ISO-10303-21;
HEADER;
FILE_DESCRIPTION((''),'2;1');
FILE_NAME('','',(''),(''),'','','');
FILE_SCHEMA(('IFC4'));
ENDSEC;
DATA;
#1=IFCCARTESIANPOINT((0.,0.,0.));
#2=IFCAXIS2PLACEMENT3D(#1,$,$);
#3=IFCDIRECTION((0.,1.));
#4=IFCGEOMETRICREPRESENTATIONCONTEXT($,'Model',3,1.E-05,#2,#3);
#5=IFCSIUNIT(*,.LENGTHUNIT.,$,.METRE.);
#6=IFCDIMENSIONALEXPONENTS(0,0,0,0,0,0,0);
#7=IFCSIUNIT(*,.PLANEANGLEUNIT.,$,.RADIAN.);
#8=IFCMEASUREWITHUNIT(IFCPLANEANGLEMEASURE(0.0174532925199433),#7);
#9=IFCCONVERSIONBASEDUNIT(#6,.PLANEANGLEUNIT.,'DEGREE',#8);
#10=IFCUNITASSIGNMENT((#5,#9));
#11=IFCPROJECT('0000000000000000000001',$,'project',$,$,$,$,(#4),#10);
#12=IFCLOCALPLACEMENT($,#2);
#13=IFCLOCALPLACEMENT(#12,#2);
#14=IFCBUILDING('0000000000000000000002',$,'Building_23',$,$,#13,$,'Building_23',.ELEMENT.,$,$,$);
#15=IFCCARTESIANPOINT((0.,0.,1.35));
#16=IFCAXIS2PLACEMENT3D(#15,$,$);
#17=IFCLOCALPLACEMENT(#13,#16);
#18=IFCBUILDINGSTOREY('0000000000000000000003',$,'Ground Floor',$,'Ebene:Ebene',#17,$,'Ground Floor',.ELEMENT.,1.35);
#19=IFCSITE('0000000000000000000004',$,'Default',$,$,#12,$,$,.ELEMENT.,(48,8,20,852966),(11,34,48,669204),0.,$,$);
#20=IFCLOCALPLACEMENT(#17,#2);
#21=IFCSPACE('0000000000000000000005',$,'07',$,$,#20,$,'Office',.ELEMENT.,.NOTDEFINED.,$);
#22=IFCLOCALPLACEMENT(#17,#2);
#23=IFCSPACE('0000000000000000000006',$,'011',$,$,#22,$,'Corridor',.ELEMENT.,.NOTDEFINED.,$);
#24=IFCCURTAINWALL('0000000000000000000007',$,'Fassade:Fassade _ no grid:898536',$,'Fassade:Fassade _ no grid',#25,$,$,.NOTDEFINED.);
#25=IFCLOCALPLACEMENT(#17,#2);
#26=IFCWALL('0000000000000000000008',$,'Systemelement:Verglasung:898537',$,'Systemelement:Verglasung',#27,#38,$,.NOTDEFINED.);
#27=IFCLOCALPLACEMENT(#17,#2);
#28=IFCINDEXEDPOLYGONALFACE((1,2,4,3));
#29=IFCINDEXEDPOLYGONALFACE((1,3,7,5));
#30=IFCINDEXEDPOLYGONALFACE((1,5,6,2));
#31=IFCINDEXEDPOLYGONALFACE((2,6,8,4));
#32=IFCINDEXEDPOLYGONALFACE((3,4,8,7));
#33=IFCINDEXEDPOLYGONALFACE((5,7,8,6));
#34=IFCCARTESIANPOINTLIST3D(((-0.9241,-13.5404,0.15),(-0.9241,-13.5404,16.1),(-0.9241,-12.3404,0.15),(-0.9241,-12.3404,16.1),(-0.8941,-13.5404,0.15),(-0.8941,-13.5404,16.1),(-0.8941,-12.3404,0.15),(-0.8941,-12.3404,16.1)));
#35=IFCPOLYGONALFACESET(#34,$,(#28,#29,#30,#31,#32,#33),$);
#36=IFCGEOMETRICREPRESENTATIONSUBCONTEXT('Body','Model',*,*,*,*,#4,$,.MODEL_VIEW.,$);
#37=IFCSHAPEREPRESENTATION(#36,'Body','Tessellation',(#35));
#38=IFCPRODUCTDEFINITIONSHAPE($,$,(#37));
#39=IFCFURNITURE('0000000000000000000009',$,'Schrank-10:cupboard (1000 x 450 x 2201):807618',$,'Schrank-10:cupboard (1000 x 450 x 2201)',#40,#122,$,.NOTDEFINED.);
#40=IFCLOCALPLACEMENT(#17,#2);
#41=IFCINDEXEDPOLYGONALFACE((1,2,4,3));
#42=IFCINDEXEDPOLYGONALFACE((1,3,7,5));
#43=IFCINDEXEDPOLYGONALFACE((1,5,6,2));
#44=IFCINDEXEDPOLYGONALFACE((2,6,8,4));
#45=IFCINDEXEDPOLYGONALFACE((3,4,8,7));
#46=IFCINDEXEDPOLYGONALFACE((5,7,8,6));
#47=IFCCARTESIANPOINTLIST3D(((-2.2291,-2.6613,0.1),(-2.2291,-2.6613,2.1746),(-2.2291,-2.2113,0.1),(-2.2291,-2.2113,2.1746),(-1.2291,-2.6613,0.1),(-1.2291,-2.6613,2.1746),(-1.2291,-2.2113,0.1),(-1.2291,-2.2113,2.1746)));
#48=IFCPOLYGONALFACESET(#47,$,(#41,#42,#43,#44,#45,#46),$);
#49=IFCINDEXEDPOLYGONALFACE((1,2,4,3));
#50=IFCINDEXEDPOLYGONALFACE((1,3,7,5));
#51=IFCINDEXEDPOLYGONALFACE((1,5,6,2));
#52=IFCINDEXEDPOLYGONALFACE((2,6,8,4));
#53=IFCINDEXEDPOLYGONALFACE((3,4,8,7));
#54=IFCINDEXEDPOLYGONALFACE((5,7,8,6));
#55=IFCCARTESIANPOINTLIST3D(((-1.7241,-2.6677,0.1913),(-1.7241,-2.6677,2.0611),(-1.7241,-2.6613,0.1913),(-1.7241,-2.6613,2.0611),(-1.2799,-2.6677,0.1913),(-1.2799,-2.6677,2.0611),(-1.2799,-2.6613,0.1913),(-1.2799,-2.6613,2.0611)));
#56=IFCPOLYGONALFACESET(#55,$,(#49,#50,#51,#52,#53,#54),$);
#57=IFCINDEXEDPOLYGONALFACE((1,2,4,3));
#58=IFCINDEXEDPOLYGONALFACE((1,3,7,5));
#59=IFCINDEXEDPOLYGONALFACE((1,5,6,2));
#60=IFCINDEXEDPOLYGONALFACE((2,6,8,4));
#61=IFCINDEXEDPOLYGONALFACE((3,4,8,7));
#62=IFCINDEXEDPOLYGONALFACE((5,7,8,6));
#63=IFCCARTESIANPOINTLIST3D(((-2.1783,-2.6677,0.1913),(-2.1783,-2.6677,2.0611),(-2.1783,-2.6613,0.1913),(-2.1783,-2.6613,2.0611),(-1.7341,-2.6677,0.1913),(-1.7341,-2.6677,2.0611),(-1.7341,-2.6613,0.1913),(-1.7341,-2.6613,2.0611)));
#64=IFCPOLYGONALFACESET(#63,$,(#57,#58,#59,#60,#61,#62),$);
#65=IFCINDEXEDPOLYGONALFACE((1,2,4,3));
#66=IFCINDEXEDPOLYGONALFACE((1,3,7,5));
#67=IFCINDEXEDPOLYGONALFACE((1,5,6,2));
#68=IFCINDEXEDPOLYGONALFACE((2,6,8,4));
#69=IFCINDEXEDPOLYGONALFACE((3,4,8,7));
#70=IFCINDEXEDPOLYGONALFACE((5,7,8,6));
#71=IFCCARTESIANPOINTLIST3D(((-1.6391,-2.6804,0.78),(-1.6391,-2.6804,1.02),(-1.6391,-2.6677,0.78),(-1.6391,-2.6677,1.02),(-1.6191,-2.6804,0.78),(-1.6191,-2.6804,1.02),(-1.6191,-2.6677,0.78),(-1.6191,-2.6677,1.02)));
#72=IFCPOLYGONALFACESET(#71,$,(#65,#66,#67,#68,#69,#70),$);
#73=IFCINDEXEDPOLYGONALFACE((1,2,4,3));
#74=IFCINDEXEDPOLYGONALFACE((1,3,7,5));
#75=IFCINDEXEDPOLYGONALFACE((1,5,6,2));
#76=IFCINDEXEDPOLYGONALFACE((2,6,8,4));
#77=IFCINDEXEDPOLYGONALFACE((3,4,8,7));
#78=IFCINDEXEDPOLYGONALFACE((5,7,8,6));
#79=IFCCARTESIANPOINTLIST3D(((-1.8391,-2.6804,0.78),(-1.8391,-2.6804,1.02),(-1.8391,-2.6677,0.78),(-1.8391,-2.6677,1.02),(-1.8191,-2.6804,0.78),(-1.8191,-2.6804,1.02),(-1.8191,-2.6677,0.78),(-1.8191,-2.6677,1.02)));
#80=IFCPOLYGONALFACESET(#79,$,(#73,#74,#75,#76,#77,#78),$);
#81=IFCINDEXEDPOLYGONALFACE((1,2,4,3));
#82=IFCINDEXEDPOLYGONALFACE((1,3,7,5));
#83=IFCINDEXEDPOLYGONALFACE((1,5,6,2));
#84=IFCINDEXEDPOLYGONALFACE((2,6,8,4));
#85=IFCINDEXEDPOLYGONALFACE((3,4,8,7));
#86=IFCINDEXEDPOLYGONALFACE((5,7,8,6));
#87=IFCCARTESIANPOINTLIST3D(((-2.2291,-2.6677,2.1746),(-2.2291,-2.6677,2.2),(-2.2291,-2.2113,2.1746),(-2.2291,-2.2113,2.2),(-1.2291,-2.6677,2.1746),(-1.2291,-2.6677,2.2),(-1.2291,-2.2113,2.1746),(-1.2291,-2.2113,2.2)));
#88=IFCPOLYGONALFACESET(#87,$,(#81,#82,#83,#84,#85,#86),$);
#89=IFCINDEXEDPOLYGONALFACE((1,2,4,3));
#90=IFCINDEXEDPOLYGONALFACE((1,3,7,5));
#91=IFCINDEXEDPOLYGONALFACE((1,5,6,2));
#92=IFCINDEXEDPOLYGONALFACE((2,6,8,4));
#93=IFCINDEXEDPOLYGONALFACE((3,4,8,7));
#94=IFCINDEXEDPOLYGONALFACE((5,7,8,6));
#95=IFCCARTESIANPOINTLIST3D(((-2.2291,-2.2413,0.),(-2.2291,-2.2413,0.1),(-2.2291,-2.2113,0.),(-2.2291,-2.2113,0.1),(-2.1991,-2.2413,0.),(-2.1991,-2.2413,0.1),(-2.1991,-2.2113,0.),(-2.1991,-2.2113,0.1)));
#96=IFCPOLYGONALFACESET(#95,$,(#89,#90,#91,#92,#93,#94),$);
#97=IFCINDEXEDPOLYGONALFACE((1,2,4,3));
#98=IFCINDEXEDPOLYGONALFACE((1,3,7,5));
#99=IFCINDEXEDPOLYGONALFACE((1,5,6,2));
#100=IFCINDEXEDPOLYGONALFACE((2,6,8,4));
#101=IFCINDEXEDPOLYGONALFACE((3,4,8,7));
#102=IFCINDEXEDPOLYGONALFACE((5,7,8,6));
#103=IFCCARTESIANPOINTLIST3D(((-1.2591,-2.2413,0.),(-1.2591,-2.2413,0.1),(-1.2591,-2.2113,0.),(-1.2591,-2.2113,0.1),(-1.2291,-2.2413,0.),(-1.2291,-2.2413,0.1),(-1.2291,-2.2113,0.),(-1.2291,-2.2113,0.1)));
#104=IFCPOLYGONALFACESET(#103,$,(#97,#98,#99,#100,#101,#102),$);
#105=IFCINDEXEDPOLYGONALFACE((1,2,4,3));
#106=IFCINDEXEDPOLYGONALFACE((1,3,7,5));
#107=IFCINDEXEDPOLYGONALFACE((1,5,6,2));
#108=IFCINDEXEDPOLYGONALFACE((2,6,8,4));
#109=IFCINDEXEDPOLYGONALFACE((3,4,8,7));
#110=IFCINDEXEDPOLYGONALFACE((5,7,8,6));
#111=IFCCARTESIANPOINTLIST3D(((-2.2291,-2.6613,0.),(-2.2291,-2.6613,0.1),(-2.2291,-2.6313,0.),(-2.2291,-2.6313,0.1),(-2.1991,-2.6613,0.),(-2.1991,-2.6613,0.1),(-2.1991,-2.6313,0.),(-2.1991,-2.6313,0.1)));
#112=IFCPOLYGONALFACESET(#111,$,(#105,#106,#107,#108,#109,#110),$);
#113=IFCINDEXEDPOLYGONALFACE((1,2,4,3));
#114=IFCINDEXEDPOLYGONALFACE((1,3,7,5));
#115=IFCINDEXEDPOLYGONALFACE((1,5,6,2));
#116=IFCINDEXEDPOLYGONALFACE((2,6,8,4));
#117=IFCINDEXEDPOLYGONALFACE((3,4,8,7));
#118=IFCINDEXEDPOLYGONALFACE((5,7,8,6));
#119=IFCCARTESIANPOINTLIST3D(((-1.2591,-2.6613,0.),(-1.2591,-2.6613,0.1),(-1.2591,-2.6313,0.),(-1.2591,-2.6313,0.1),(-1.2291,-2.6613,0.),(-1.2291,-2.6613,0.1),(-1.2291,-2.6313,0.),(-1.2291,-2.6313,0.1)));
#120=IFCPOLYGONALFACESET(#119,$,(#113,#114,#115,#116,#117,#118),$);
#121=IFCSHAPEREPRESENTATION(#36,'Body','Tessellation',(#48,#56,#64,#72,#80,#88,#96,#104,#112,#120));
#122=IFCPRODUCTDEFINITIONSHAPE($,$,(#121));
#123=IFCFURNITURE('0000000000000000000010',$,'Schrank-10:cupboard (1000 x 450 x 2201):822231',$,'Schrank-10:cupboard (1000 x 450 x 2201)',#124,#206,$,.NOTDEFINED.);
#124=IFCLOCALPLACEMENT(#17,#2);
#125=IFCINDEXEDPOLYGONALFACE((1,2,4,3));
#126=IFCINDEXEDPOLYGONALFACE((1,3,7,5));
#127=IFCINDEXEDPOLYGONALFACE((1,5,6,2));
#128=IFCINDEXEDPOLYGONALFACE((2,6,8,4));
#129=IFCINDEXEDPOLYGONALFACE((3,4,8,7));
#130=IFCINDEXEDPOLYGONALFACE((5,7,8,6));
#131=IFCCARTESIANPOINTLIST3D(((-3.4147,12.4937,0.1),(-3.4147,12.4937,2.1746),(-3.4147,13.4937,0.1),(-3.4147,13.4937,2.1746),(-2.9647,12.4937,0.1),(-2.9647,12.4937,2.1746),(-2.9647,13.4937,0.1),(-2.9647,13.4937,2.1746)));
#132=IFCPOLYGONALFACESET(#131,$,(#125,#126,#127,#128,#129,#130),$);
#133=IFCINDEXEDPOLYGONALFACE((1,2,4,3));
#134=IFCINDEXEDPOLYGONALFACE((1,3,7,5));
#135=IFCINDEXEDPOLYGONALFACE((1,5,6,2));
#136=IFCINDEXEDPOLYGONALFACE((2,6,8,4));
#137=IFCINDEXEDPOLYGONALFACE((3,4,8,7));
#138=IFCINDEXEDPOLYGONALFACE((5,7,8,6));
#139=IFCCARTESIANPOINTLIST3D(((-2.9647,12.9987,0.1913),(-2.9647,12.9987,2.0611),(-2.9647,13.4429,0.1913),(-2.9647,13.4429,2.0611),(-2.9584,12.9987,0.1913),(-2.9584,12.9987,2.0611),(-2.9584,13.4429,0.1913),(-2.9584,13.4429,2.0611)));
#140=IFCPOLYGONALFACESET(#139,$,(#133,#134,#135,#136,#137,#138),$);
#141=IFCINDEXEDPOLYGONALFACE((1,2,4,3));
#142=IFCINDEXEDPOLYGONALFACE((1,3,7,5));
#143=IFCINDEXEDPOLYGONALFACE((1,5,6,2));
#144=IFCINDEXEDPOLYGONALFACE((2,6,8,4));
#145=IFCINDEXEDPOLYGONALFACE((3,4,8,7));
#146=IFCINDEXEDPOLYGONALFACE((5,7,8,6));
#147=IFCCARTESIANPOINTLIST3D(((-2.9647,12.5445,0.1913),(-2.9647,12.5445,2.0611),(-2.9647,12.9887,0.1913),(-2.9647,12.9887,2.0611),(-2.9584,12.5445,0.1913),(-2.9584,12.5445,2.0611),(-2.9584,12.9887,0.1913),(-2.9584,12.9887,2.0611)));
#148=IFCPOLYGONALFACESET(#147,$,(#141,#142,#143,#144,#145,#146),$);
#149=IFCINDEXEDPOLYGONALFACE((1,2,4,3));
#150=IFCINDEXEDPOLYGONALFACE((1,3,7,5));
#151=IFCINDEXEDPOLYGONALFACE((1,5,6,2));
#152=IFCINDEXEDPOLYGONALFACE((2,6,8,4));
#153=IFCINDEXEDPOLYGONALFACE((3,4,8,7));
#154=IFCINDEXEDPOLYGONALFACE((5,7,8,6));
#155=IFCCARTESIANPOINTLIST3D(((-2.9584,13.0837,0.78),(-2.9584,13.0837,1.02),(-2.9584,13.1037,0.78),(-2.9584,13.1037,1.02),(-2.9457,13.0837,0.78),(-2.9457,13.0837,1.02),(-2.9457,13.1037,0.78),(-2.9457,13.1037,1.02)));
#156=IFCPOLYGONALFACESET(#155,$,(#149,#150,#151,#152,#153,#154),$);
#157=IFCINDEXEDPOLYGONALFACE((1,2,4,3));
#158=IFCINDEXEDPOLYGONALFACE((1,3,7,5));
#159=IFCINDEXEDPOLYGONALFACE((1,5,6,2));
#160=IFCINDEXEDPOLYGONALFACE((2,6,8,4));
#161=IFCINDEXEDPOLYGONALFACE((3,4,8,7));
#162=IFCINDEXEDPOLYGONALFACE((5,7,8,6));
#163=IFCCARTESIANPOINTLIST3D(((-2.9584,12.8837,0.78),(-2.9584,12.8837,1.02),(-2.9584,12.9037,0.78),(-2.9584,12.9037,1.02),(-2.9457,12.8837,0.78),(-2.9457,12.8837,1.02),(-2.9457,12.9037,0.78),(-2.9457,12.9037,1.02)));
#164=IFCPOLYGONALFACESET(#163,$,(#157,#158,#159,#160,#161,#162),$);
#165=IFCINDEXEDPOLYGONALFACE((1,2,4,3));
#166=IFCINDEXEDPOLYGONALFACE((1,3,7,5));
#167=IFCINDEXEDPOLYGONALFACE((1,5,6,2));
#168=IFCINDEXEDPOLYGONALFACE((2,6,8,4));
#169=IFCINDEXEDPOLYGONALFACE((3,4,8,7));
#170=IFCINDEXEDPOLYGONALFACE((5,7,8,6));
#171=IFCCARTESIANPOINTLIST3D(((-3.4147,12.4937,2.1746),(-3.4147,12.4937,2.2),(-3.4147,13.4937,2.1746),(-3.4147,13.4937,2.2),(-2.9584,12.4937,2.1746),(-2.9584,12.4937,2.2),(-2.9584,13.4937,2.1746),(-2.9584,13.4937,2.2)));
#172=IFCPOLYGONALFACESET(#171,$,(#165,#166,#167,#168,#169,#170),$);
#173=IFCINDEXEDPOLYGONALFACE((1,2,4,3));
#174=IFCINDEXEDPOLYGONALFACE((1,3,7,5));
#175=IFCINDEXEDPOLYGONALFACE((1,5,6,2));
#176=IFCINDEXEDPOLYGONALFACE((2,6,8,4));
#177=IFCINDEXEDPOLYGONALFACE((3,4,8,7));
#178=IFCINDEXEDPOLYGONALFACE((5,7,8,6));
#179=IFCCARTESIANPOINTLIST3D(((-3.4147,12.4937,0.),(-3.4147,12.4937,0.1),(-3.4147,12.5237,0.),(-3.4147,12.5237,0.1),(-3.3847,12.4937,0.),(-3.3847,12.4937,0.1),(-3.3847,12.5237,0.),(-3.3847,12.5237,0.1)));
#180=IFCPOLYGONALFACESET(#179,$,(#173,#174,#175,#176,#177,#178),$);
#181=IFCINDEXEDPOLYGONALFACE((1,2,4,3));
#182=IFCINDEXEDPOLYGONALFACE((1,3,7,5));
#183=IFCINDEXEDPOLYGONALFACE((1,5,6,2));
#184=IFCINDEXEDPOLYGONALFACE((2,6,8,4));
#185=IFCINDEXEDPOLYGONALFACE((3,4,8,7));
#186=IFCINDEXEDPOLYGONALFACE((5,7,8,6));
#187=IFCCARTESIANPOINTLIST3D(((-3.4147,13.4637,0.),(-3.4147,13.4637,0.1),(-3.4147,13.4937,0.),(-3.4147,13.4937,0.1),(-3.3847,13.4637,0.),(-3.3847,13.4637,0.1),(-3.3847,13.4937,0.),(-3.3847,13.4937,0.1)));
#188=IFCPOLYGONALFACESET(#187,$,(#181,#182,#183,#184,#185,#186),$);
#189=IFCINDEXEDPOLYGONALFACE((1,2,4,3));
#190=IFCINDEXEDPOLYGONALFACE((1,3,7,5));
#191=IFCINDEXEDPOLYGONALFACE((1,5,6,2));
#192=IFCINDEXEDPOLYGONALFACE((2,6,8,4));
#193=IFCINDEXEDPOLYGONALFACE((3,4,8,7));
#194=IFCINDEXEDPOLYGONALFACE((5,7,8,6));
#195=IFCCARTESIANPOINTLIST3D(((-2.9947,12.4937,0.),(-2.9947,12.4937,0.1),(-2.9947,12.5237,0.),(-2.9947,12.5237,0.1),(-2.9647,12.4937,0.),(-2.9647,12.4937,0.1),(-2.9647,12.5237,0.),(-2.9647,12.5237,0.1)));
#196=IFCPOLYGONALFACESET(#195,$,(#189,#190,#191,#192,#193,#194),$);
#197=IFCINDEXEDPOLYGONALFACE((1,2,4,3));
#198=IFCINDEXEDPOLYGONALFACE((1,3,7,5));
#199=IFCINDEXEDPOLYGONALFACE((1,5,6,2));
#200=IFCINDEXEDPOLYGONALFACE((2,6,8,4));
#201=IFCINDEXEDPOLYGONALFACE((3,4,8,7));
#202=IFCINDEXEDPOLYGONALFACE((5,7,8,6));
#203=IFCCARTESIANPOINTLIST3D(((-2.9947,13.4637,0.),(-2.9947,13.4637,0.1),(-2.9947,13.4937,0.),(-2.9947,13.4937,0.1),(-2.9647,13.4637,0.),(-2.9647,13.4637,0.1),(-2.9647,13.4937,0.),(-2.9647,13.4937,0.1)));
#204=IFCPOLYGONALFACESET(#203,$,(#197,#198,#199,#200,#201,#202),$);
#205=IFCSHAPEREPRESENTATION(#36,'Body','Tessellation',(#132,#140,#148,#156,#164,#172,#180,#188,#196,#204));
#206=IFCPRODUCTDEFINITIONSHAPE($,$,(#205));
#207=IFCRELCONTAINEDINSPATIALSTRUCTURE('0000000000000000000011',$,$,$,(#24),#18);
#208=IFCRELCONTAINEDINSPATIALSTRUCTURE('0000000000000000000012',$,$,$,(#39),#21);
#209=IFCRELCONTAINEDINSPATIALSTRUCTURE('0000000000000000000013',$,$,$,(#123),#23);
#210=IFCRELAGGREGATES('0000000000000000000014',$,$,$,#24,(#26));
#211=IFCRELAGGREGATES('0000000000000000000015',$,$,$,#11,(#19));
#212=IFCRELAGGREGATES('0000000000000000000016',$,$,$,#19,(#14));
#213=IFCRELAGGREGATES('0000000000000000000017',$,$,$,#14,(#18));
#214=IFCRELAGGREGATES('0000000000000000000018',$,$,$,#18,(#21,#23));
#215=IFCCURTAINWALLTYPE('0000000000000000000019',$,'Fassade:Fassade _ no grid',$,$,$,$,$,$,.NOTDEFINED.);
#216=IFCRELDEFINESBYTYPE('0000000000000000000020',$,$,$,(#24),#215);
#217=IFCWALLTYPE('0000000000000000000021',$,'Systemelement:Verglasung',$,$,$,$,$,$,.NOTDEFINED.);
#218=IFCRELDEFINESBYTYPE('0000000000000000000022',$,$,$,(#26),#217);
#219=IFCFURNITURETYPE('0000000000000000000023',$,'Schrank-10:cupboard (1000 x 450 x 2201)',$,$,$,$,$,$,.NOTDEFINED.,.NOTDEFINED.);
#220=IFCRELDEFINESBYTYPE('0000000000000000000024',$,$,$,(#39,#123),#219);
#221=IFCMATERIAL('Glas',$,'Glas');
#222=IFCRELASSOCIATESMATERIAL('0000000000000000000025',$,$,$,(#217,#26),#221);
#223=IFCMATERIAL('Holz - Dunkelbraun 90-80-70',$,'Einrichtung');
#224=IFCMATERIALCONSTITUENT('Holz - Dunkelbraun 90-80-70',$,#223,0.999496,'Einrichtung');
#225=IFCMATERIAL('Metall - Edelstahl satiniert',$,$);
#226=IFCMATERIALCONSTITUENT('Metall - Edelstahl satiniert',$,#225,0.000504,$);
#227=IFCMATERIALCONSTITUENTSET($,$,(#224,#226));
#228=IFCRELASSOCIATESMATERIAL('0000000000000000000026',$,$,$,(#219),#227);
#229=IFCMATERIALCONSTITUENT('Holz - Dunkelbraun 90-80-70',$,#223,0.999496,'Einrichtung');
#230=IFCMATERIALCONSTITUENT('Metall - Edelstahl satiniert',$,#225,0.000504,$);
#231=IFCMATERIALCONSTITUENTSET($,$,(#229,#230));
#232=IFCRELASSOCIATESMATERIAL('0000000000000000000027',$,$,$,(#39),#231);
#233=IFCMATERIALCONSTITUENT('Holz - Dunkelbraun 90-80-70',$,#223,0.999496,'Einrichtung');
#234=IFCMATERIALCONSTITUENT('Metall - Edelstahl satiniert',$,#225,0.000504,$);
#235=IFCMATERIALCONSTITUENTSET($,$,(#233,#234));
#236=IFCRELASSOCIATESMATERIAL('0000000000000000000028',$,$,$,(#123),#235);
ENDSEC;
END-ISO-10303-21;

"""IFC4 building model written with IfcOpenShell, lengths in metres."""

from ifc_helpers import new_model, entity, si_unit, converted_unit, direction, frame, origin, place, context, subcontext, project, spatial, indexed_curve, outline, extrude, source, transform, mapped, material, constituent, constituent_set, type_object, type_shapes, element, aggregate, save


model = new_model("IFC4")

# Units and contexts
model_context = context("Model", 3, precision=1e-05, world=origin(), true_north=direction((0.0, 1.0)))
body_context = subcontext(model_context, "Body", "Model", "MODEL_VIEW")
ifc_project = project(units=[si_unit("LENGTHUNIT", "METRE"), converted_unit("PLANEANGLEUNIT", "DEGREE", entity("IfcPlaneAngleMeasure", 0.0174532925199433), si_unit("PLANEANGLEUNIT", "RADIAN"), dimensions=[0, 0, 0, 0, 0, 0, 0])], contexts=[model_context])

# Site, building, storey
site_placement = place(None, origin())
site = spatial("IfcSite", under=ifc_project, at=site_placement, Name="Default", CompositionType="ELEMENT", RefLatitude=(48, 8, 20, 852966), RefLongitude=(11, 34, 48, 669204), RefElevation=0.0)
building_placement = place(site_placement, origin())
building = spatial("IfcBuilding", under=site, at=building_placement, Name="Building_23", LongName="Building_23", CompositionType="ELEMENT")
storey_placement = place(building_placement, frame((0.0, 0.0, 1.35)))
storey = spatial("IfcBuildingStorey", under=building, at=storey_placement, Name="Ground Floor", ObjectType="Ebene:Ebene", LongName="Ground Floor", CompositionType="ELEMENT", Elevation=1.35)

# Curtain wall, wall
curtain_wall_type = type_object("IfcCurtainWallType", Name="Fassade:Fassade _ no grid", PredefinedType="NOTDEFINED")
curtain_wall_placement = place(storey_placement, frame((0.0, 0.0, -1.35)))
curtain_wall = element("IfcCurtainWall", 1, at=curtain_wall_placement, inside=storey, type_object=curtain_wall_type, Name="Fassade:Fassade _ no grid:898536", ObjectType="Fassade:Fassade _ no grid", PredefinedType="NOTDEFINED")
ifc_material_1 = material(Name="Glas", Category="Glas")
wall_type_1 = type_object("IfcWallType", Name="Systemelement:Verglasung", PredefinedType="NOTDEFINED", material=ifc_material_1)
shared_shape_1 = source(origin(), body_context, "Body", "SweptSolid", [
    extrude(outline(indexed_curve([(-0.015, -0.6), (0.015, -0.6), (0.015, 0.6), (-0.015, 0.6), (-0.015, -0.6)], self_intersect=False)), frame((0.0, 0.0, 0.0), z_axis=(0.0, 0.0, 1.0), x_axis=(0.0, 1.0, 0.0)), (0.0, 0.0, 1.0), 15.95),
])
type_shapes(wall_type_1, [shared_shape_1])
wall_1_placement = place(storey_placement, frame((-0.9091, -12.9404, 0.15), z_axis=(0.0, 0.0, 1.0), x_axis=(0.0, -1.0, 0.0)))
wall_1 = element("IfcWall", 2, at=wall_1_placement, type_object=wall_type_1, material=ifc_material_1, Name="Systemelement:Verglasung:898537", ObjectType="Systemelement:Verglasung", PredefinedType="NOTDEFINED", context=body_context, shape_type="MappedRepresentation", body=[
    mapped(shared_shape_1, transform((0.0, 0.0, 0.0), scale=1.0)),
])
aggregate(curtain_wall, [wall_1])

# Shared definitions
space_1_placement = place(storey_placement, origin())
space_1 = spatial("IfcSpace", under=storey, at=space_1_placement, Name="07", LongName="Office", CompositionType="ELEMENT", PredefinedType="NOTDEFINED")

# Furniture
ifc_material_2 = material(Name="Holz - Dunkelbraun 90-80-70", Category="Einrichtung")
ifc_constituent_1 = constituent(ifc_material_2, Name="Holz - Dunkelbraun 90-80-70", Category="Einrichtung", fraction=0.999496)
ifc_material_3 = material(Name="Metall - Edelstahl satiniert")
ifc_constituent_2 = constituent(ifc_material_3, Name="Metall - Edelstahl satiniert", fraction=0.000504)
ifc_constituent_set_1 = constituent_set(constituents=[ifc_constituent_1, ifc_constituent_2])
ifc_constituent_3 = constituent(ifc_material_2, Name="Holz - Dunkelbraun 90-80-70", Category="Einrichtung", fraction=0.999496)
ifc_constituent_4 = constituent(ifc_material_3, Name="Metall - Edelstahl satiniert", fraction=0.000504)
ifc_constituent_set_2 = constituent_set(constituents=[ifc_constituent_3, ifc_constituent_4])
furniture_type = type_object("IfcFurnitureType", Name="Schrank-10:cupboard (1000 x 450 x 2201)", AssemblyPlace="NOTDEFINED", PredefinedType="NOTDEFINED", material=ifc_constituent_set_2)
shared_shape_2 = source(origin(), body_context, "Body", "SweptSolid", [
    extrude(outline(indexed_curve([(-0.225, -0.5), (0.225, -0.5), (0.225, 0.5), (-0.225, 0.5), (-0.225, -0.5)], self_intersect=False)), frame((-0.2692, -0.3632, 0.1), z_axis=(0.0, 0.0, 1.0), x_axis=(0.0, 1.0, 0.0)), (0.0, 0.0, 1.0), 2.0746),
    extrude(outline(indexed_curve([(-0.0032, -0.2221), (0.0032, -0.2221), (0.0032, 0.2221), (-0.0032, 0.2221), (-0.0032, -0.2221)], self_intersect=False)), frame((-0.0421, -0.5913, 0.1913), z_axis=(0.0, 0.0, 1.0), x_axis=(0.0, 1.0, 0.0)), (0.0, 0.0, 1.0), 1.8698),
    extrude(outline(indexed_curve([(-0.0032, -0.2221), (0.0032, -0.2221), (0.0032, 0.2221), (-0.0032, 0.2221), (-0.0032, -0.2221)], self_intersect=False)), frame((-0.4963, -0.5913, 0.1913), z_axis=(0.0, 0.0, 1.0), x_axis=(0.0, 1.0, 0.0)), (0.0, 0.0, 1.0), 1.8698),
    extrude(outline(indexed_curve([(-0.0063, -0.01), (0.0063, -0.01), (0.0063, 0.01), (-0.0063, 0.01), (-0.0063, -0.01)], self_intersect=False)), frame((-0.1692, -0.6009, 0.78), z_axis=(0.0, 0.0, 1.0), x_axis=(0.0, 1.0, 0.0)), (0.0, 0.0, 1.0), 0.24),
    extrude(outline(indexed_curve([(-0.0063, -0.01), (0.0063, -0.01), (0.0063, 0.01), (-0.0063, 0.01), (-0.0063, -0.01)], self_intersect=False)), frame((-0.3692, -0.6009, 0.78), z_axis=(0.0, 0.0, 1.0), x_axis=(0.0, 1.0, 0.0)), (0.0, 0.0, 1.0), 0.24),
    extrude(outline(indexed_curve([(-0.5, -0.2282), (0.5, -0.2282), (0.5, 0.2282), (-0.5, 0.2282), (-0.5, -0.2282)], self_intersect=False)), frame((-0.2692, -0.3663, 2.1746), z_axis=(0.0, 0.0, 1.0), x_axis=(-1.0, 0.0, 0.0)), (0.0, 0.0, 1.0), 0.0254),
    extrude(outline(indexed_curve([(-0.015, -0.015), (0.015, -0.015), (0.015, 0.015), (-0.015, 0.015), (-0.015, -0.015)], self_intersect=False)), frame((-0.7542, -0.1532, 0.0), z_axis=(0.0, 0.0, 1.0), x_axis=(-1.0, 0.0, 0.0)), (0.0, 0.0, 1.0), 0.1),
    extrude(outline(indexed_curve([(-0.015, -0.015), (0.015, -0.015), (0.015, 0.015), (-0.015, 0.015), (-0.015, -0.015)], self_intersect=False)), frame((0.2158, -0.1532, 0.0), z_axis=(0.0, 0.0, 1.0), x_axis=(0.0, -1.0, 0.0)), (0.0, 0.0, 1.0), 0.1),
    extrude(outline(indexed_curve([(-0.015, -0.015), (0.015, -0.015), (0.015, 0.015), (-0.015, 0.015), (-0.015, -0.015)], self_intersect=False)), frame((-0.7542, -0.5732, 0.0), z_axis=(0.0, 0.0, 1.0), x_axis=(0.0, 1.0, 0.0)), (0.0, 0.0, 1.0), 0.1),
    extrude(outline(indexed_curve([(-0.015, -0.015), (0.015, -0.015), (0.015, 0.015), (-0.015, 0.015), (-0.015, -0.015)], self_intersect=False)), frame((0.2158, -0.5732, 0.0)), (0.0, 0.0, 1.0), 0.1),
])
type_shapes(furniture_type, [shared_shape_2])
furniture_1_placement = place(space_1_placement, frame((-1.4599, -2.0731, 0.0)))
element("IfcFurniture", 3, at=furniture_1_placement, inside=space_1, type_object=furniture_type, material=ifc_constituent_set_1, Name="Schrank-10:cupboard (1000 x 450 x 2201):807618", ObjectType="Schrank-10:cupboard (1000 x 450 x 2201)", PredefinedType="NOTDEFINED", context=body_context, shape_type="MappedRepresentation", body=[
    mapped(shared_shape_2, transform((0.0, 0.0, 0.0), scale=1.0)),
])

# Shared definitions
space_2_placement = place(storey_placement, origin())
space_2 = spatial("IfcSpace", under=storey, at=space_2_placement, Name="011", LongName="Corridor", CompositionType="ELEMENT", PredefinedType="NOTDEFINED")

# Furniture
ifc_constituent_5 = constituent(ifc_material_2, Name="Holz - Dunkelbraun 90-80-70", Category="Einrichtung", fraction=0.999496)
ifc_constituent_6 = constituent(ifc_material_3, Name="Metall - Edelstahl satiniert", fraction=0.000504)
ifc_constituent_set_3 = constituent_set(constituents=[ifc_constituent_5, ifc_constituent_6])
furniture_2_placement = place(space_2_placement, frame((-3.5529, 13.2629, 0.0), z_axis=(0.0, 0.0, 1.0), x_axis=(0.0, 1.0, 0.0)))
element("IfcFurniture", 4, at=furniture_2_placement, inside=space_2, type_object=furniture_type, material=ifc_constituent_set_3, Name="Schrank-10:cupboard (1000 x 450 x 2201):822231", ObjectType="Schrank-10:cupboard (1000 x 450 x 2201)", PredefinedType="NOTDEFINED", context=body_context, shape_type="MappedRepresentation", body=[
    mapped(shared_shape_2, transform((0.0, 0.0, 0.0), scale=1.0)),
])

save(model, "model.ifc")
